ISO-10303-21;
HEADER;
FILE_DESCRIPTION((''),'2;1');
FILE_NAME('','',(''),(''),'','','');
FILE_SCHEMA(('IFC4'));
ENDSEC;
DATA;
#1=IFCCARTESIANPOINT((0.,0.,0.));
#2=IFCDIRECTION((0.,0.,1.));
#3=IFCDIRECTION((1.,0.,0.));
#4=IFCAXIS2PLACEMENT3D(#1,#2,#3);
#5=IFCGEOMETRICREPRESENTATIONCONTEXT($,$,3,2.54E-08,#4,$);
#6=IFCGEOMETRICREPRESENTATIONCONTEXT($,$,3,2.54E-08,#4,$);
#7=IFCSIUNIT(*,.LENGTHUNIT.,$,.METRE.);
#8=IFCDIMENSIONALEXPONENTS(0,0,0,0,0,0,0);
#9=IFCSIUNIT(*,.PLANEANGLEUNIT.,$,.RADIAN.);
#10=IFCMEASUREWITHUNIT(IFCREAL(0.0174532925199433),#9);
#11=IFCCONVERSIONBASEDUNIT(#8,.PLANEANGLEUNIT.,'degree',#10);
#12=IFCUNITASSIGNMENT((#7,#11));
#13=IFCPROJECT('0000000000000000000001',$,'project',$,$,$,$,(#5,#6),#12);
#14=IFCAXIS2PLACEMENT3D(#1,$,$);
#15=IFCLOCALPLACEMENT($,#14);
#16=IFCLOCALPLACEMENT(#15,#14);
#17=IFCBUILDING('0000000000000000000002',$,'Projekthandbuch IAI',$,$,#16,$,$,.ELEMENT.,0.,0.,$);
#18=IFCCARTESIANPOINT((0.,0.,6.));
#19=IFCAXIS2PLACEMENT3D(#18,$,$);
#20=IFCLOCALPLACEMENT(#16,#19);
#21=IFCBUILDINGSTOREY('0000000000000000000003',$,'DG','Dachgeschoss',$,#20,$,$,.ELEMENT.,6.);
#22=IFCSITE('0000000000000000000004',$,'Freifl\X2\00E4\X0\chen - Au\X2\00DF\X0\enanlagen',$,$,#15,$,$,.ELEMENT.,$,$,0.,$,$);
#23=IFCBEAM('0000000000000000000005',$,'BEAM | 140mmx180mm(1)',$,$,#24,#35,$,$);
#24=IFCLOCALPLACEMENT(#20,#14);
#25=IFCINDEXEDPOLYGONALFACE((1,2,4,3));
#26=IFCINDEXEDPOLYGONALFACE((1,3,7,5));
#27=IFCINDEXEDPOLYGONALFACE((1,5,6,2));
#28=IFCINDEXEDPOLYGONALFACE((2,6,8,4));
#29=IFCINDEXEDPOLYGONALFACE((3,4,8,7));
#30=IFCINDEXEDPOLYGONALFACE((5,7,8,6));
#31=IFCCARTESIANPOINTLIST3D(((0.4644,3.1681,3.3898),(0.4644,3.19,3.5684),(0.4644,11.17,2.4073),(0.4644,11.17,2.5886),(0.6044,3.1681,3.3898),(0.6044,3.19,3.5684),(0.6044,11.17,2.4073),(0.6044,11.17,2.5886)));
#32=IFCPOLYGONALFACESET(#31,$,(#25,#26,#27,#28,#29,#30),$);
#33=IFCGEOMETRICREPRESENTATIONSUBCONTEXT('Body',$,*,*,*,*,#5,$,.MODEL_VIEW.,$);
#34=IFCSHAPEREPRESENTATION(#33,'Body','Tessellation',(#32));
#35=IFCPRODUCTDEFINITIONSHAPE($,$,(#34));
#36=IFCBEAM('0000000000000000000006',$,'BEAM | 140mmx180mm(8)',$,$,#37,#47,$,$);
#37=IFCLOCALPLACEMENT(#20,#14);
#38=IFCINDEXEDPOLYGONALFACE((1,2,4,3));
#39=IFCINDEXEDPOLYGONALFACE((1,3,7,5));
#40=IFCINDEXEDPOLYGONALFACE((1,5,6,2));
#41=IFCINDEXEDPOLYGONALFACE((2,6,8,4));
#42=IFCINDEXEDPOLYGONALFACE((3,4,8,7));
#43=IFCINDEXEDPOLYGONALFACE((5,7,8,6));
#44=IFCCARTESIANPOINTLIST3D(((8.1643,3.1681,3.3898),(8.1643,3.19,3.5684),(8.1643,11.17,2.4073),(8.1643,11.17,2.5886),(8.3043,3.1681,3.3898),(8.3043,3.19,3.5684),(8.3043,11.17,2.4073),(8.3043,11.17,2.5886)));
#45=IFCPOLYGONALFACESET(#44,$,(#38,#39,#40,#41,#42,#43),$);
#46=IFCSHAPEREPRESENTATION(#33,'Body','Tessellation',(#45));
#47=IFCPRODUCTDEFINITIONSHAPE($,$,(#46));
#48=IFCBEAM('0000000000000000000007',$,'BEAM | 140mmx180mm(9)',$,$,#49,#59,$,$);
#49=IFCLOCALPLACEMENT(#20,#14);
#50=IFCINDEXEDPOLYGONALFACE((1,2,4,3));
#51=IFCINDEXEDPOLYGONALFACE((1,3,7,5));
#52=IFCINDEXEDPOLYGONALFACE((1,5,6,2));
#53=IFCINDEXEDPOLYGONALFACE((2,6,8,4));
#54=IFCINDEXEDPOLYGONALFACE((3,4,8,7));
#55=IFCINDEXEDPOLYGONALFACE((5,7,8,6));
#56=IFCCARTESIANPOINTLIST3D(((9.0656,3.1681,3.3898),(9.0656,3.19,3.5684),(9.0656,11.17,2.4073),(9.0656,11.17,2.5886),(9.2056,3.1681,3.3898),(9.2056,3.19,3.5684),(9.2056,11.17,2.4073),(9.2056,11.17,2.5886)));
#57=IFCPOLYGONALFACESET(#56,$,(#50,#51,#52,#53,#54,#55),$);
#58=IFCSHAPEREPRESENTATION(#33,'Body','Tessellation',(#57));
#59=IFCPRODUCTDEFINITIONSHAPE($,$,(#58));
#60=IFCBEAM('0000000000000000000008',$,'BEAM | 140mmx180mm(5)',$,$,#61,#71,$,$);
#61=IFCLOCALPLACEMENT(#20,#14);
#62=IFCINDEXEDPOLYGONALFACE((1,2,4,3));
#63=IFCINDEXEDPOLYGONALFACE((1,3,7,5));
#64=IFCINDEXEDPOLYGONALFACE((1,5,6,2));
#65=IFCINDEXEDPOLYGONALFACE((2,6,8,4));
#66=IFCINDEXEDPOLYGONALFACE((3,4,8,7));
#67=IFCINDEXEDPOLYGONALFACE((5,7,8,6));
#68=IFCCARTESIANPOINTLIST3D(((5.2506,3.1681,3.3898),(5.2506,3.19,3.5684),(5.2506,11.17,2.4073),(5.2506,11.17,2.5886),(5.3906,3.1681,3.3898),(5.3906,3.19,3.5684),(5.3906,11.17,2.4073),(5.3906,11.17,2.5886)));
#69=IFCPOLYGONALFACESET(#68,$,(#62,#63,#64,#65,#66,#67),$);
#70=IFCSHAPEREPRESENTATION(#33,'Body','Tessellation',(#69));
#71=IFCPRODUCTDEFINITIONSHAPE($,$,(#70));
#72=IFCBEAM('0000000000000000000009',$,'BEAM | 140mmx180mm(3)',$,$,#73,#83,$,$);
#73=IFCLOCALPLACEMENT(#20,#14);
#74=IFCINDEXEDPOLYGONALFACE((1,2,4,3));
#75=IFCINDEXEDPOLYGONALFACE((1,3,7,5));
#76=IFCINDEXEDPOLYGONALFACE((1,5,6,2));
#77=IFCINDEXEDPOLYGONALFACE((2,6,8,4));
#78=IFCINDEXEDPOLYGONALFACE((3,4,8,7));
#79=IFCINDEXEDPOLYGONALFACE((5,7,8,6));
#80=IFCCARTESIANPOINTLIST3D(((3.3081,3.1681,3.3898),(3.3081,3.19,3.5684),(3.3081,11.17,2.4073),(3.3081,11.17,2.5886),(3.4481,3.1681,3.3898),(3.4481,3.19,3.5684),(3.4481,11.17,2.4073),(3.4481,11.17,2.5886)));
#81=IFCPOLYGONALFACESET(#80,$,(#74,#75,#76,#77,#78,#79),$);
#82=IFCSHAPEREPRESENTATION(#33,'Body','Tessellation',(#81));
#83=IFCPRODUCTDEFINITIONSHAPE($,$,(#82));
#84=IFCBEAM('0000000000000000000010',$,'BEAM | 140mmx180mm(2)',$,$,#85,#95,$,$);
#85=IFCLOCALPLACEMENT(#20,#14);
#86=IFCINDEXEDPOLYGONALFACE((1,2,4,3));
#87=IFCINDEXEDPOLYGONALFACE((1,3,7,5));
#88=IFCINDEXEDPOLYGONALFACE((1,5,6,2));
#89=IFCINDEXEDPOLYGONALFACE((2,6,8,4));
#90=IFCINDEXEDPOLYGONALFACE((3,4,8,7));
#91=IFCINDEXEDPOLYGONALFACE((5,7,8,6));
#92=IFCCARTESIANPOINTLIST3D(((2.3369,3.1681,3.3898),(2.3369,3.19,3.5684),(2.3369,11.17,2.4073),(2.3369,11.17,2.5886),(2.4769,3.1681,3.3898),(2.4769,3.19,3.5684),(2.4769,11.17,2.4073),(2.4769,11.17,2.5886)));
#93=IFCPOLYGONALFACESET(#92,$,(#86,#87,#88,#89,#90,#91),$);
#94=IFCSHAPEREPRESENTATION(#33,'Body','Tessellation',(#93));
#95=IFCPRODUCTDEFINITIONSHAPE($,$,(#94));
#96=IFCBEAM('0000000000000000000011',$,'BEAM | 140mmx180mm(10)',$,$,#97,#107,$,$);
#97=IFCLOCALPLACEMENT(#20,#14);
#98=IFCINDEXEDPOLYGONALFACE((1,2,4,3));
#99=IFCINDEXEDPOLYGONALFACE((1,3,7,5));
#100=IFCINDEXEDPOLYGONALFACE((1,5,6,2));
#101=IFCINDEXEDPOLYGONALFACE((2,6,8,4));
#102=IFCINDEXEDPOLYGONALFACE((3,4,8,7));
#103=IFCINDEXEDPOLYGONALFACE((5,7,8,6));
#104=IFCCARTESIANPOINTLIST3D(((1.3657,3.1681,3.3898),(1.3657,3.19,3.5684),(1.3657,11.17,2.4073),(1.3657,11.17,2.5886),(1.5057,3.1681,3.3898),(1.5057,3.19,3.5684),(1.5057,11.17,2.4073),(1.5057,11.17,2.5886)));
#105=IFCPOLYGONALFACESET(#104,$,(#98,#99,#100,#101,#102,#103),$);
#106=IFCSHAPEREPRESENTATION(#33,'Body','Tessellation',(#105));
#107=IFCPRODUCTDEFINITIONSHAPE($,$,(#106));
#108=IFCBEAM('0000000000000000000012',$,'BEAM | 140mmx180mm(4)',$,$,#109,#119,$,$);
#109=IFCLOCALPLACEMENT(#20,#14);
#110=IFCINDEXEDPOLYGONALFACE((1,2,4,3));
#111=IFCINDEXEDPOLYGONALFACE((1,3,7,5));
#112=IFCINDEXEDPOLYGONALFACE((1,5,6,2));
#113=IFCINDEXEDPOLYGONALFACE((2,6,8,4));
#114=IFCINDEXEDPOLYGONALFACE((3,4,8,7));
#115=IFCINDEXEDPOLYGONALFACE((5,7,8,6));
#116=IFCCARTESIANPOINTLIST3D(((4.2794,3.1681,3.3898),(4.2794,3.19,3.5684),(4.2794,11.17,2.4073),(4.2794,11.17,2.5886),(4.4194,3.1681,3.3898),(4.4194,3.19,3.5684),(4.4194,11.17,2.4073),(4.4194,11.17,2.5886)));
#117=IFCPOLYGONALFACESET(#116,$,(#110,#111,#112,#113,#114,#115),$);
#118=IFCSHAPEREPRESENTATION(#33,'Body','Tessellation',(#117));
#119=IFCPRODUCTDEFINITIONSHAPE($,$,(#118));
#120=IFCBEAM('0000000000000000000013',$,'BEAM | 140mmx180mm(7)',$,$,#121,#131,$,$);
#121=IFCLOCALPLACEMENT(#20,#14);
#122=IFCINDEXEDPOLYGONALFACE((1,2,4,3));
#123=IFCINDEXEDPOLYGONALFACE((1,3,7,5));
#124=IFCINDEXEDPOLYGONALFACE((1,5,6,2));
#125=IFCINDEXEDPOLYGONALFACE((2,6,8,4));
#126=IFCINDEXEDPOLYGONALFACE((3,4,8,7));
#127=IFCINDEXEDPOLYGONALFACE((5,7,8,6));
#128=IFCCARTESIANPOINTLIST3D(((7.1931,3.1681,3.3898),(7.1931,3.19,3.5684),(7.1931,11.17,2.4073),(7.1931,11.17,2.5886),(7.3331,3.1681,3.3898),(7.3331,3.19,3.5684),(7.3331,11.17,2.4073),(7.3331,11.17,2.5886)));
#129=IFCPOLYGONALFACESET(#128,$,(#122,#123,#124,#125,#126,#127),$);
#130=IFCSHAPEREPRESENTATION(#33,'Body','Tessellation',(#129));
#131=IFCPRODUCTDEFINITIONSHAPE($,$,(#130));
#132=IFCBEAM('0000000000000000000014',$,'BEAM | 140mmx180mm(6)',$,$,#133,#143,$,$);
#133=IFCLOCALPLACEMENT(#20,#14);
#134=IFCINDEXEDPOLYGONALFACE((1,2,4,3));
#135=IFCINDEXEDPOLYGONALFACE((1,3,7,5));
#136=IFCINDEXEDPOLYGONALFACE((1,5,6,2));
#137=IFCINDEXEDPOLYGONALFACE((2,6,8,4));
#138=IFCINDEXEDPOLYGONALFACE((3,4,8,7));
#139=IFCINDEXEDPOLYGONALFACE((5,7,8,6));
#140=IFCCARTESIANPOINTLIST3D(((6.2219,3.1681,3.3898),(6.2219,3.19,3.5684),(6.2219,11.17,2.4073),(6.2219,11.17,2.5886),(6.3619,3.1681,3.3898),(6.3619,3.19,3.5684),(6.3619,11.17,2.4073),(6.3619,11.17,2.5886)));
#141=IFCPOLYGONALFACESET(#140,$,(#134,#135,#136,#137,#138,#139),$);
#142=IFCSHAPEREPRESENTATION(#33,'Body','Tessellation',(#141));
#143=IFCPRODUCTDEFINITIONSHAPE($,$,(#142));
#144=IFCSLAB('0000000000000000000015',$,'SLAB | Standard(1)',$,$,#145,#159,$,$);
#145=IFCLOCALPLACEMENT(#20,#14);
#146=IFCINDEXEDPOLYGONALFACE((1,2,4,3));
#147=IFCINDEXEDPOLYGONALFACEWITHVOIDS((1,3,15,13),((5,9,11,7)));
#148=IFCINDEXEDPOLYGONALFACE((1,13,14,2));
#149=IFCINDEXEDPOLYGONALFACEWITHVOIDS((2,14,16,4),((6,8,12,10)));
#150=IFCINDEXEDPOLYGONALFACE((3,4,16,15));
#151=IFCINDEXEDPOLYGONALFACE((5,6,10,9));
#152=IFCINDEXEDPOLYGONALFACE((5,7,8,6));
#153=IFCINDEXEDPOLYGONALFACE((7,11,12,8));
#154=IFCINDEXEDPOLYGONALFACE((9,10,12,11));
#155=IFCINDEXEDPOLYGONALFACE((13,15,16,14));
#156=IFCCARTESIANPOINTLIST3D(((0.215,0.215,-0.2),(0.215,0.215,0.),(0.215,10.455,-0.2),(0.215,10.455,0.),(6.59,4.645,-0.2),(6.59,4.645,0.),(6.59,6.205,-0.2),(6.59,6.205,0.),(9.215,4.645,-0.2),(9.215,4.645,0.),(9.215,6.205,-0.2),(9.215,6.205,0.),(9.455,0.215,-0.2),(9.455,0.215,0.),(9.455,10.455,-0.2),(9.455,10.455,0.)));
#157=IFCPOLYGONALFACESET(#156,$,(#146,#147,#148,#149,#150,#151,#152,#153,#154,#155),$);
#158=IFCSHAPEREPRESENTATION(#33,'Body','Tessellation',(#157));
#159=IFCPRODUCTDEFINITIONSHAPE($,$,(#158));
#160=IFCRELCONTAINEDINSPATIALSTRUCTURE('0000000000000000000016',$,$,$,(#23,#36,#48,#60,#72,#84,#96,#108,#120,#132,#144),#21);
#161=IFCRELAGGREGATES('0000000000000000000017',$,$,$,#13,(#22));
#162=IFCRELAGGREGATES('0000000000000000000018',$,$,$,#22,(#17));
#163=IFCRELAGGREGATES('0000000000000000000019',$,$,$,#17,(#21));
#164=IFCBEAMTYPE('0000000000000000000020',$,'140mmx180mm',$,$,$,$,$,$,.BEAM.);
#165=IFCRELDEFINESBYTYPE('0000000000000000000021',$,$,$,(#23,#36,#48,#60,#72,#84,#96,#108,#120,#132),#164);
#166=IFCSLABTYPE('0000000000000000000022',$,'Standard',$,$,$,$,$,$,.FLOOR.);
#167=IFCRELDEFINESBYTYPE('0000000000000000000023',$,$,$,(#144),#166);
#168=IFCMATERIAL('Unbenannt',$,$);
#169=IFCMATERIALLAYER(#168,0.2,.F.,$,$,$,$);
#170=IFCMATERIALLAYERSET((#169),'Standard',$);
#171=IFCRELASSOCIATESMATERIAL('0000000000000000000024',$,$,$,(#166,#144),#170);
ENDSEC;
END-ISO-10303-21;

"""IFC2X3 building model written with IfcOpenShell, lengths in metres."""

from ifc_helpers import new_model, entity, si_unit, converted_unit, frame, frame_2d, origin, origin_with_axes, origin_2d_with_axis, place, context, subcontext, project, spatial, rectangle, extrude, clip, halfspace, material, layer, layer_set, layer_usage, type_object, element, save


model = new_model("IFC2X3")

# Units and contexts
context_of_model_1 = context(None, 3, precision=2.54e-08, world=origin_with_axes())
context_of_model_2 = context(None, 3, precision=2.54e-08, world=origin_with_axes())
body_context = subcontext(context_of_model_2, "Body", None, "MODEL_VIEW")
ifc_project = project(units=[si_unit("LENGTHUNIT", "METRE"), converted_unit("PLANEANGLEUNIT", "degree", entity("IfcReal", 0.0174532925199433), si_unit("PLANEANGLEUNIT", "RADIAN"), dimensions=[0, 0, 0, 0, 0, 0, 0])], contexts=[context_of_model_2, context_of_model_1])

# Site, building, storey
site_placement = place(None, origin())
site = spatial("IfcSite", under=ifc_project, at=site_placement, Name="Freiflächen - Außenanlagen", CompositionType="ELEMENT", RefElevation=0.0)
building_placement = place(site_placement, origin())
building = spatial("IfcBuilding", under=site, at=building_placement, Name="Projekthandbuch IAI", CompositionType="ELEMENT", ElevationOfRefHeight=0.0, ElevationOfTerrain=0.0)
storey_placement = place(building_placement, frame((0.0, 0.0, 6.0)))
storey = spatial("IfcBuildingStorey", under=building, at=storey_placement, Name="DG", Description="Dachgeschoss", CompositionType="ELEMENT", Elevation=6.0)

# Beams
beam_type = type_object("IfcBeamType", Name="140mmx180mm", PredefinedType="BEAM")
for number, where, z_axis, x_axis, name in (
    (1, (0.5344, 3.179, 3.4791), (0.0, 0.121869, 0.992546), (0.0, 0.992546, -0.121869), "BEAM | 140mmx180mm(1)"),
    (2, (8.2343, 3.179, 3.4791), (0.0, 0.121869, 0.992546), (0.0, 0.992546, -0.121869), "BEAM | 140mmx180mm(8)"),
    (3, (9.1356, 3.179, 3.4791), (0.0, 0.121869, 0.992546), (0.0, 0.992546, -0.121869), "BEAM | 140mmx180mm(9)"),
    (4, (5.3206, 3.179, 3.4791), (0.0, 0.121869, 0.992546), (0.0, 0.992546, -0.121869), "BEAM | 140mmx180mm(5)"),
    (5, (3.3781, 3.179, 3.4791), (0.0, 0.121869, 0.992546), (0.0, 0.992546, -0.121869), "BEAM | 140mmx180mm(3)"),
    (6, (2.4069, 3.179, 3.4791), (0.0, 0.121869, 0.992546), (0.0, 0.992546, -0.121869), "BEAM | 140mmx180mm(2)"),
    (7, (1.4357, 3.179, 3.4791), (0.0, 0.121869, 0.992546), (0.0, 0.992546, -0.121869), "BEAM | 140mmx180mm(10)"),
    (8, (4.3494, 3.179, 3.4791), (0.0, 0.121869, 0.992546), (0.0, 0.992546, -0.121869), "BEAM | 140mmx180mm(4)"),
):
    element("IfcBeam", number, at=place(storey_placement, frame(where, z_axis=z_axis, x_axis=x_axis)), inside=storey, type_object=beam_type, Name=name, context=body_context, shape_type="Clipping", held_by="IfcProductRepresentation", body=[
        clip(extrude(rectangle(XDim=0.14, YDim=0.18, at=origin_2d_with_axis()), frame((0.0, 0.0, 0.0), z_axis=(1.0, 0.0, 0.0), x_axis=(0.0, 1.0, 0.0)), (0.0, 0.0, 1.0), 8.268), halfspace(frame((8.051, 0.0, 0.0), z_axis=(0.992546, 0.0, 0.121869), x_axis=(0.0, 1.0, 0.0)), False)),
    ])
beam_1_placement = place(storey_placement, frame((7.2631, 3.179, 3.4791), z_axis=(0.0, 0.121869, 0.992546), x_axis=(0.0, 0.992546, -0.121869)))
element("IfcBeam", 9, at=beam_1_placement, inside=storey, type_object=beam_type, Name="BEAM | 140mmx180mm(7)", context=body_context, shape_type="Clipping", held_by="IfcProductRepresentation", body=[
    clip(extrude(rectangle(XDim=0.14, YDim=0.18, at=origin_2d_with_axis()), frame((0.0, 0.0, 0.0), z_axis=(1.0, 0.0, 0.0), x_axis=(0.0, 1.0, 0.0)), (0.0, 0.0, 1.0), 8.268), halfspace(frame((8.051, 0.0, 0.0), z_axis=(0.992546, 0.0, 0.121869), x_axis=(0.0, 1.0, 0.0)), False)),
])
beam_2_placement = place(storey_placement, frame((6.2919, 3.179, 3.4791), z_axis=(0.0, 0.121869, 0.992546), x_axis=(0.0, 0.992546, -0.121869)))
element("IfcBeam", 10, at=beam_2_placement, inside=storey, type_object=beam_type, Name="BEAM | 140mmx180mm(6)", context=body_context, shape_type="Clipping", held_by="IfcProductRepresentation", body=[
    clip(extrude(rectangle(XDim=0.14, YDim=0.18, at=origin_2d_with_axis()), frame((0.0, 0.0, 0.0), z_axis=(1.0, 0.0, 0.0), x_axis=(0.0, 1.0, 0.0)), (0.0, 0.0, 1.0), 8.268), halfspace(frame((8.051, 0.0, 0.0), z_axis=(0.992546, 0.0, 0.121869), x_axis=(0.0, 1.0, 0.0)), False)),
])

# Slab, opening
ifc_material_1 = material(Name="Unbenannt")
ifc_layer_1 = layer(ifc_material_1, 0.2, ventilated=False)
ifc_layer_set_1 = layer_set([ifc_layer_1], Name="Standard")
ifc_layer_usage_1 = layer_usage(ifc_layer_set_1, "AXIS3", "POSITIVE", 0.0)
slab_type = type_object("IfcSlabType", Name="Standard", PredefinedType="FLOOR", material=ifc_layer_set_1)
slab_placement = place(storey_placement, frame((0.215, 10.455, -0.2), z_axis=(0.0, 0.0, 1.0), x_axis=(0.0, -1.0, 0.0)))
slab = element("IfcSlab", 11, at=slab_placement, inside=storey, type_object=slab_type, material=ifc_layer_usage_1, Name="SLAB | Standard(1)", context=body_context, shape_type="SweptSolid", held_by="IfcProductRepresentation", body=[
    extrude(rectangle(XDim=10.24, YDim=9.24, at=frame_2d((5.12, 4.62), x_axis=(1.0, 0.0))), origin(), (0.0, 0.0, 1.0), 0.2),
])
opening_1_placement = place(slab_placement, frame((5.03, 7.6875, 0.0)))
element("IfcOpeningElement", 12, at=opening_1_placement, cuts=slab, context=body_context, shape_type="SweptSolid", held_by="IfcProductRepresentation", body=[
    extrude(rectangle(XDim=1.56, YDim=2.625, at=frame_2d((0.0, 0.0), x_axis=(1.0, 0.0))), frame((0.0, 0.0, -0.2)), (0.0, 0.0, 1.0), 0.6),
])

save(model, "model.ifc")
